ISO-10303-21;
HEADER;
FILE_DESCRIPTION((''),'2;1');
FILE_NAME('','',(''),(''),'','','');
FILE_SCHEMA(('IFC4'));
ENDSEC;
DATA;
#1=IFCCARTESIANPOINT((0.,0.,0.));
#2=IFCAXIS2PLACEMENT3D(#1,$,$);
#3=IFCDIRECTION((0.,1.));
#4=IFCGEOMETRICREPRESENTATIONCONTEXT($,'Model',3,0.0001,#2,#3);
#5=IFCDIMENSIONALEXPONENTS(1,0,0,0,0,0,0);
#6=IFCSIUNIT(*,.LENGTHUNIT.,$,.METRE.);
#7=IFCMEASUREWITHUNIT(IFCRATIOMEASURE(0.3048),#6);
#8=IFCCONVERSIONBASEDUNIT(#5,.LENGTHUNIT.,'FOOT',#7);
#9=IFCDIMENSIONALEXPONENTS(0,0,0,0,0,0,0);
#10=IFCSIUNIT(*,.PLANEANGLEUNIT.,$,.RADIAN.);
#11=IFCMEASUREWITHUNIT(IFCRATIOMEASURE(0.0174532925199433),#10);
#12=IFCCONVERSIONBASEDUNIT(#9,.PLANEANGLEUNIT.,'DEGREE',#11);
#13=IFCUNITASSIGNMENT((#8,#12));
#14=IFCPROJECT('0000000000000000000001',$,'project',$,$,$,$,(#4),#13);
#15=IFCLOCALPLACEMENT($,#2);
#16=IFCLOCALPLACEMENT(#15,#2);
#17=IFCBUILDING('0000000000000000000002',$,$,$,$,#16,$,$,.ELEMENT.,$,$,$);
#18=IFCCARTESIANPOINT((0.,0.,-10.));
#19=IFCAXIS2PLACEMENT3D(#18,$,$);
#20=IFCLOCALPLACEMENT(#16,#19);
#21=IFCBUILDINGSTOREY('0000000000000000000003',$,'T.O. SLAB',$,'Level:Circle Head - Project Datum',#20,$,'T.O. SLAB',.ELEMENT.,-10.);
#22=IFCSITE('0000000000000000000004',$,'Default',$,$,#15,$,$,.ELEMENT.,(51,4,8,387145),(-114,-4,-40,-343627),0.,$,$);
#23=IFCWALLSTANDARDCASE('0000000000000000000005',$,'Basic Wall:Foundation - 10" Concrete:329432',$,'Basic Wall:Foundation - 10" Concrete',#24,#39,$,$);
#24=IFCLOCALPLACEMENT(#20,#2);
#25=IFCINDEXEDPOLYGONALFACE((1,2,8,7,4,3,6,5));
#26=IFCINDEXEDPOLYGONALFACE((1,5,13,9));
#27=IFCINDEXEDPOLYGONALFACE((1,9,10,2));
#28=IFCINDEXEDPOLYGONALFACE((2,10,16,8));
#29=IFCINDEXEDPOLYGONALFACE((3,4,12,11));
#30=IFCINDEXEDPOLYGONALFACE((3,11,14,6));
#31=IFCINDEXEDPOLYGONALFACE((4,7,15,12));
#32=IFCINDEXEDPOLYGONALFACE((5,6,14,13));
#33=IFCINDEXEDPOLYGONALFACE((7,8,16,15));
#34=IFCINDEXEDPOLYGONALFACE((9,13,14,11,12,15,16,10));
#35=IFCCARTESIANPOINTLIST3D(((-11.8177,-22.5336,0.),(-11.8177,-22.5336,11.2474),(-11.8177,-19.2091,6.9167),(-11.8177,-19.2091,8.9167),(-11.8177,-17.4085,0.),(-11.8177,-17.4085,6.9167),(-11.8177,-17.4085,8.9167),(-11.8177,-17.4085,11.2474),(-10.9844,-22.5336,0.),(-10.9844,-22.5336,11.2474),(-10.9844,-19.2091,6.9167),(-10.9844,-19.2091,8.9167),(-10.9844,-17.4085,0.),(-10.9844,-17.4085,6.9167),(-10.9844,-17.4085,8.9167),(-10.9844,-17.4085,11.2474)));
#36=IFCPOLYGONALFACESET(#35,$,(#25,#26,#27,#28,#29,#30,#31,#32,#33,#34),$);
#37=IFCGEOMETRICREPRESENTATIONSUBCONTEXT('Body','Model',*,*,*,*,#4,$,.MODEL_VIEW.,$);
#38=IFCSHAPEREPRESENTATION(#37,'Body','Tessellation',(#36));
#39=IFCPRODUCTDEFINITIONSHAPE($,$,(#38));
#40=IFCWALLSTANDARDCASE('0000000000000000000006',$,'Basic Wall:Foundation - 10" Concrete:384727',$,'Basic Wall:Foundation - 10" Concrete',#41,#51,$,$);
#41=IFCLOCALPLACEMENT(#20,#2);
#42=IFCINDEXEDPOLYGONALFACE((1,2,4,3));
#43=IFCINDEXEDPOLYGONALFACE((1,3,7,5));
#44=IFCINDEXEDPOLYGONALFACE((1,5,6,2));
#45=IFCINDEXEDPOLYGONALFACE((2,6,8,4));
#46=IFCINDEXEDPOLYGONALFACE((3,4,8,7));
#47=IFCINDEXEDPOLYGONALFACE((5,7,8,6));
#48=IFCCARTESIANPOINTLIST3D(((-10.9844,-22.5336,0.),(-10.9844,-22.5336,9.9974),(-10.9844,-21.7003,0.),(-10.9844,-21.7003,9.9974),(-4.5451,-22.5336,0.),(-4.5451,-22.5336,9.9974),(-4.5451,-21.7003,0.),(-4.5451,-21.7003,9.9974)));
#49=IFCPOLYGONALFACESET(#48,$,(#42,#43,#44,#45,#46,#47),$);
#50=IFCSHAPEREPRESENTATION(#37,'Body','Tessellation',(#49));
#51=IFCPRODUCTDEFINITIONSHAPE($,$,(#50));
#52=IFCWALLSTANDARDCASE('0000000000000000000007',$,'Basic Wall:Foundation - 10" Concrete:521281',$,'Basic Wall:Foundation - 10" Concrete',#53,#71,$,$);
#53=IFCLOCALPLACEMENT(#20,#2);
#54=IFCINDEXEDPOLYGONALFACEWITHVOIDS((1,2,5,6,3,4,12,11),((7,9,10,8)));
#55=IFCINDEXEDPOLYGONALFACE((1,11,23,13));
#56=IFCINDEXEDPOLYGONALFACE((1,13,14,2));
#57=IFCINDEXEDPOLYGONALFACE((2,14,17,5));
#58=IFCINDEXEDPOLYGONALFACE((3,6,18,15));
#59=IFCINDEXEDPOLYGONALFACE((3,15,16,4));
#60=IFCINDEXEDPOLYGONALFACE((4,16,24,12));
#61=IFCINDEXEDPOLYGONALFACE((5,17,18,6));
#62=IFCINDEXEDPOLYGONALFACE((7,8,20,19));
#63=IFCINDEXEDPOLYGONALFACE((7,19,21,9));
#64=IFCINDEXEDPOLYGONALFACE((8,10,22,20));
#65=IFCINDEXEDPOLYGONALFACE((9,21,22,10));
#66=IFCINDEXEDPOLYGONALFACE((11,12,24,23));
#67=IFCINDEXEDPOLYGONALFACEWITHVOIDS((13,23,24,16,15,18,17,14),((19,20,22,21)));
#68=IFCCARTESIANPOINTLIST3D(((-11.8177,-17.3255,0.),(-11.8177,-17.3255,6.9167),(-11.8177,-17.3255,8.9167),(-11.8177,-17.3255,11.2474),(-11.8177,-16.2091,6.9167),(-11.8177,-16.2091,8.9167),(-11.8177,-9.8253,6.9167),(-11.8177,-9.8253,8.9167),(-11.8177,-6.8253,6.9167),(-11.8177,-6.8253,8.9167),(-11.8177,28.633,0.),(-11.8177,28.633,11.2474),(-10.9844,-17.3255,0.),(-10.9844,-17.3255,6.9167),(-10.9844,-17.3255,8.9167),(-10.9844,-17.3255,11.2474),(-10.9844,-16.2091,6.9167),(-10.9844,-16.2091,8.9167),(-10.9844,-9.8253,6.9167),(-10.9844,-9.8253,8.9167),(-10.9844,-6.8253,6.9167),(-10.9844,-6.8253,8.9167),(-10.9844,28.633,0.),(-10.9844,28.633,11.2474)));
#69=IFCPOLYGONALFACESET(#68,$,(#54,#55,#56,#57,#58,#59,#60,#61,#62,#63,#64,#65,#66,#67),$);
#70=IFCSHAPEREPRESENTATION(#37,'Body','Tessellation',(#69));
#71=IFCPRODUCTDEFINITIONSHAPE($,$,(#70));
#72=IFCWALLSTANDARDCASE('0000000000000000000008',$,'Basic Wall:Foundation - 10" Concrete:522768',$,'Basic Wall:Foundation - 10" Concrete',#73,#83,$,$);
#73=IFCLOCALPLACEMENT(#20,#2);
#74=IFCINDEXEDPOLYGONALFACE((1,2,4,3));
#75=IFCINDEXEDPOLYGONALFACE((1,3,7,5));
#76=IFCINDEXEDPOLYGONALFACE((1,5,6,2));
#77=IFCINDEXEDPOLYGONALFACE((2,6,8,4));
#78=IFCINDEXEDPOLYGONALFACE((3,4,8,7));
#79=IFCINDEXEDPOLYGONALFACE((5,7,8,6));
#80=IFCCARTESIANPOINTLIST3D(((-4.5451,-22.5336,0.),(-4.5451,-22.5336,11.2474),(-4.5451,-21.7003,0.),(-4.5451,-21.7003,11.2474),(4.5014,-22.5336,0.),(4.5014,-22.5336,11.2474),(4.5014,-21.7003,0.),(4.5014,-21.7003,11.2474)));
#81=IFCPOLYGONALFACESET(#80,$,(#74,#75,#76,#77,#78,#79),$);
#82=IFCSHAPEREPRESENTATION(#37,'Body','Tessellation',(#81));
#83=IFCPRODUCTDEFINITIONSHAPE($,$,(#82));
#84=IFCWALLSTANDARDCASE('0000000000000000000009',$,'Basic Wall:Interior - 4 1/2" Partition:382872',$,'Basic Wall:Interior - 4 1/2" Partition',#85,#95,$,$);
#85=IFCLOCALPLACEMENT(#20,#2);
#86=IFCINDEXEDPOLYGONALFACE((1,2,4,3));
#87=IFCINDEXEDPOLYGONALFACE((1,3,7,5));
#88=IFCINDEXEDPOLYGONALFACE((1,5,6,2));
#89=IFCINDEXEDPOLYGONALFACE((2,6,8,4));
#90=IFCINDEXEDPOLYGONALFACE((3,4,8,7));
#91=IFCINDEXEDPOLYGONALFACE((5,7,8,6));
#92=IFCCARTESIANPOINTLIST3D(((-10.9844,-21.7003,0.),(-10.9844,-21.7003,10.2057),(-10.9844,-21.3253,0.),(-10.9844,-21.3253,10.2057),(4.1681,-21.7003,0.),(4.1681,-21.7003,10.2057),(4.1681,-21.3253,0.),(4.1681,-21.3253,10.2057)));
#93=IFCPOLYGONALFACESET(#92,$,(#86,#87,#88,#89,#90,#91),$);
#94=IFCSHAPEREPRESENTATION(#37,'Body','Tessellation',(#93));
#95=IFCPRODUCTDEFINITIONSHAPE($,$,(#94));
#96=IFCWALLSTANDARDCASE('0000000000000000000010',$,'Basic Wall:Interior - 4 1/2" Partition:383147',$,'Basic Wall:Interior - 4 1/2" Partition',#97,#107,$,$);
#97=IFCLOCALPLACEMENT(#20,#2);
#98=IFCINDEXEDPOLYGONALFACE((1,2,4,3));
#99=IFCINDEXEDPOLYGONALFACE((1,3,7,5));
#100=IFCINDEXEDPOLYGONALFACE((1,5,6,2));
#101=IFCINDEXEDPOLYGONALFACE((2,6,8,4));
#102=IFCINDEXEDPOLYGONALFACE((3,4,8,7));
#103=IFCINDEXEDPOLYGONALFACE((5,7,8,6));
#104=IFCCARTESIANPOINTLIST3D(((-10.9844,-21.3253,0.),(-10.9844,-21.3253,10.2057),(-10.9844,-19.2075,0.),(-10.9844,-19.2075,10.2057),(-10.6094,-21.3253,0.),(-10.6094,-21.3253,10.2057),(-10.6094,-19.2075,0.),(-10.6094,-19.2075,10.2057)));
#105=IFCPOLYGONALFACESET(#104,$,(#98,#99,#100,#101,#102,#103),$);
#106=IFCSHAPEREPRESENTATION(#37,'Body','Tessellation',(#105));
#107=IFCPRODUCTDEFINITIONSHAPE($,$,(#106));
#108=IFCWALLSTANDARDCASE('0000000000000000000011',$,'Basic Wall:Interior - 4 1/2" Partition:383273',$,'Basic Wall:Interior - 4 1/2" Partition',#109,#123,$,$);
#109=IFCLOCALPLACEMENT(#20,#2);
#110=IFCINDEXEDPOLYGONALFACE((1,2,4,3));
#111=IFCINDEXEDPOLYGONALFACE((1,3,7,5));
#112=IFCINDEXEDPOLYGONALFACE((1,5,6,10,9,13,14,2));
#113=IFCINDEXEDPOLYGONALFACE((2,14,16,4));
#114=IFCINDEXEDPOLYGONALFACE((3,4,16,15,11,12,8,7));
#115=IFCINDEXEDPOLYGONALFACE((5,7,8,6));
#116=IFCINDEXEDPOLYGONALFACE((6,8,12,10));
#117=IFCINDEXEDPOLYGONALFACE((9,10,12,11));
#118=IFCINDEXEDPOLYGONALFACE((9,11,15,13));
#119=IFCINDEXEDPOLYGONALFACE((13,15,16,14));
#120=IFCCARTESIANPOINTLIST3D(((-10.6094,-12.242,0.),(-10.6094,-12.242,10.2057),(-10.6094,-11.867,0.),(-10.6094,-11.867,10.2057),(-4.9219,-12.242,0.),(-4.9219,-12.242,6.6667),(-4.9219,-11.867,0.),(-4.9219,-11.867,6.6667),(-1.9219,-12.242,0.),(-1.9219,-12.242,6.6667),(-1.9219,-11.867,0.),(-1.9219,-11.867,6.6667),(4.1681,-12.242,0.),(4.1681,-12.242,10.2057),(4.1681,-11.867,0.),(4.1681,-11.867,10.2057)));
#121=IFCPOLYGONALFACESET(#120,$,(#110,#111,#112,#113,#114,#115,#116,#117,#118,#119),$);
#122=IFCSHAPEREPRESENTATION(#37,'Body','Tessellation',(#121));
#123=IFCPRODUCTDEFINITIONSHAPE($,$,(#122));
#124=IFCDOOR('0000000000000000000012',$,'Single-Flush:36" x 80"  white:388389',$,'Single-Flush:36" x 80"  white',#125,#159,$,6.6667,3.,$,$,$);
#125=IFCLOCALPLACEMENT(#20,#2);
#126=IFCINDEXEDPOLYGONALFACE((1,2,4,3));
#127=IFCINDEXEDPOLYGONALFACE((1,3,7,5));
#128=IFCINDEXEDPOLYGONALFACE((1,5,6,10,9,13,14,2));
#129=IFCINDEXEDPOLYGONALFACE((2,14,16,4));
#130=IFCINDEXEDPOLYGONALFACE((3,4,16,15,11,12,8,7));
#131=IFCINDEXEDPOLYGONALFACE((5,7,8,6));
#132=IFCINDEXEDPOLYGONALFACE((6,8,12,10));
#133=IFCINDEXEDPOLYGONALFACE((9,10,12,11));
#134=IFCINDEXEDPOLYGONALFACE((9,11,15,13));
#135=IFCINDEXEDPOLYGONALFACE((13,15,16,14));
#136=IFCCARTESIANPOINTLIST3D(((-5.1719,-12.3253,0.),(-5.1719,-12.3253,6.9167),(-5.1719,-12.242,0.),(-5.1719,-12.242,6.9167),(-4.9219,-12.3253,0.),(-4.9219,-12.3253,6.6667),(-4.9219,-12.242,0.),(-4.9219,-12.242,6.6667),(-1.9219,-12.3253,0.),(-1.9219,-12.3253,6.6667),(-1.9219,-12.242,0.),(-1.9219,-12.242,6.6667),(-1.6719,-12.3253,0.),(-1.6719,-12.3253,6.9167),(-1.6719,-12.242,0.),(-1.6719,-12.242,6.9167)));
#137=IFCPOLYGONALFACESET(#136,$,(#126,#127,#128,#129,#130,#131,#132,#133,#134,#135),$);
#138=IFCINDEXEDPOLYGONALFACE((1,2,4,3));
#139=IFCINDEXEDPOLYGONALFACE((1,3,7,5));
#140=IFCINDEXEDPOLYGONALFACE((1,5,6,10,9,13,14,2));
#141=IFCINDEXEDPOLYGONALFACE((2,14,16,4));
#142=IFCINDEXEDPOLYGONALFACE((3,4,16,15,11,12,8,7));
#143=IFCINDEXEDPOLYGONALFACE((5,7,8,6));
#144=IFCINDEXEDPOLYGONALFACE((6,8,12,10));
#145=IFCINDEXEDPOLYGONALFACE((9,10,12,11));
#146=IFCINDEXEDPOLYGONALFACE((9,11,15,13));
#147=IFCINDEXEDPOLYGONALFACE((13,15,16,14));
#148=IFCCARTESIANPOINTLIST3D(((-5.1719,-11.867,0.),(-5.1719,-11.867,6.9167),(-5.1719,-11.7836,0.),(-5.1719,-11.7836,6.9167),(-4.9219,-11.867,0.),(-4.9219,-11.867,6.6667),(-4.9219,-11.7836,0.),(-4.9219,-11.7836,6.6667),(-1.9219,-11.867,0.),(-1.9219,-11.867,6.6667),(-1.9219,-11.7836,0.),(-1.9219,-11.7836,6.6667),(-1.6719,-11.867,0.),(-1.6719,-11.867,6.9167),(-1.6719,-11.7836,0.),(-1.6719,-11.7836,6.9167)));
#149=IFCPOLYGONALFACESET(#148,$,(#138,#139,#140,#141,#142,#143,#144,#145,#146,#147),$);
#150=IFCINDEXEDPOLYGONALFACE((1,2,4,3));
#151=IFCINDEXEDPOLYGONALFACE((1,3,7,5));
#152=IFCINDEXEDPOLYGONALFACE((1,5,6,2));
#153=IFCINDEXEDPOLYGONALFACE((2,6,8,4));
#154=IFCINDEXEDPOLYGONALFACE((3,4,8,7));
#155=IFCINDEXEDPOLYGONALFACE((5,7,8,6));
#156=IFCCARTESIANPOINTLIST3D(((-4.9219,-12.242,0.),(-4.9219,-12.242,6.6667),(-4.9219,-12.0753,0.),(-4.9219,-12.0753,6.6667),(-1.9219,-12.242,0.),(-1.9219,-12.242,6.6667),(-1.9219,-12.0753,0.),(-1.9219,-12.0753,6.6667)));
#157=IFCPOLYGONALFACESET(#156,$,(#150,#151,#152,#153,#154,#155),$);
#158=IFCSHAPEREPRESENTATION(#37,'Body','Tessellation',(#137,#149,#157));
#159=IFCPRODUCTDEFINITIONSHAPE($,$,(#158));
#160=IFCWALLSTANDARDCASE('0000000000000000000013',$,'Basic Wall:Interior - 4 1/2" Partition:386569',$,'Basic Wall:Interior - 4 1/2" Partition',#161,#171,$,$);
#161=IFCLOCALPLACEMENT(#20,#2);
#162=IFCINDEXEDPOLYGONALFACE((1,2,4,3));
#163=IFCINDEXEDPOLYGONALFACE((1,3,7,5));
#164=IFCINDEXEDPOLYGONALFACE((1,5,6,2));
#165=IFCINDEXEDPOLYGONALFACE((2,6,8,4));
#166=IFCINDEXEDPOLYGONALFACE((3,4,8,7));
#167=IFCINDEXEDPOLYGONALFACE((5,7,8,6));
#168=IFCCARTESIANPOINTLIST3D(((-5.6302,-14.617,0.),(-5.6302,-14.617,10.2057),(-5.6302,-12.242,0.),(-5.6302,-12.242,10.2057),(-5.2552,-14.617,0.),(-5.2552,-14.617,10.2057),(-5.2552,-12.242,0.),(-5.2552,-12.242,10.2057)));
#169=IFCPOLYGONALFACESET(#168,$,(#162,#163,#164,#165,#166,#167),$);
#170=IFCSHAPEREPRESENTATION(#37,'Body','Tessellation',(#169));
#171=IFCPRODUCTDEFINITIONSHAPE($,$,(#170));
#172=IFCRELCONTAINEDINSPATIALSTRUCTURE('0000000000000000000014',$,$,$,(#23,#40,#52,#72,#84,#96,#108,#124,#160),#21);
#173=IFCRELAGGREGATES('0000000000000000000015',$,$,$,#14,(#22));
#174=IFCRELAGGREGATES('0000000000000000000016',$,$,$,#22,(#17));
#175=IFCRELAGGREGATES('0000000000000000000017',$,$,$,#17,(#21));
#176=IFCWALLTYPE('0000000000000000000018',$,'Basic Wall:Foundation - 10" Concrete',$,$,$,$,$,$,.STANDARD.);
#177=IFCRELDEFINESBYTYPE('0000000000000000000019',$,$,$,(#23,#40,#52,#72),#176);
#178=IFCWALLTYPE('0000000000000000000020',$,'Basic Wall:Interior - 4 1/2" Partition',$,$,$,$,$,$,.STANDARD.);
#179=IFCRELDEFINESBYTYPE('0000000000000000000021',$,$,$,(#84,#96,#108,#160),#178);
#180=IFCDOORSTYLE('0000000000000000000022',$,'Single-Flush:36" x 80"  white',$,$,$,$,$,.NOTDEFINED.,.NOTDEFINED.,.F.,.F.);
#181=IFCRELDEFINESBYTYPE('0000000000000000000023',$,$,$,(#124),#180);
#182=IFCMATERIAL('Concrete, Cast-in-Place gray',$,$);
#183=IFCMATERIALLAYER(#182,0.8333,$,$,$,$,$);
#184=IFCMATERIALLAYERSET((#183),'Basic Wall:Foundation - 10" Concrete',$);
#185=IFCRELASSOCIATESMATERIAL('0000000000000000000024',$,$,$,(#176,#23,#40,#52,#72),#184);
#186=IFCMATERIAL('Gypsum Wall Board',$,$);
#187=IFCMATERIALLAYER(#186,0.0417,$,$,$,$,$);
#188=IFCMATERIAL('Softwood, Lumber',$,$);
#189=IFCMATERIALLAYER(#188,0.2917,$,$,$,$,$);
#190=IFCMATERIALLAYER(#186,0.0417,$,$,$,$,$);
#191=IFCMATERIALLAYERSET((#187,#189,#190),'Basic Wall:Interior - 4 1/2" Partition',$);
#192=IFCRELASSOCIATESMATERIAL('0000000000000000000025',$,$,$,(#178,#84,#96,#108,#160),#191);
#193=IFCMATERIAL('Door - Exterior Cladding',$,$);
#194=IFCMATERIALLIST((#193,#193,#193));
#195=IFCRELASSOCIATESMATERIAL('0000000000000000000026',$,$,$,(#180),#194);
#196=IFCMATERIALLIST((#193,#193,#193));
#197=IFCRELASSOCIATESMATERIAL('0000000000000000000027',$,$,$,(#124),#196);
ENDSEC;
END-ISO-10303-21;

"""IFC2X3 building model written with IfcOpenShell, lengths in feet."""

from ifc_helpers import new_model, entity, si_unit, converted_unit, direction, frame, frame_2d, origin, place, context, subcontext, project, spatial, polyline, rectangle, outline, extrude, source, transform, mapped, material, material_list, layer, layer_set, layer_usage, type_object, type_shapes, element, fill, save


model = new_model("IFC2X3")

# Units and contexts
model_context = context("Model", 3, precision=0.0001, world=origin(), true_north=direction((0.0, 1.0)))
body_context = subcontext(model_context, "Body", "Model", "MODEL_VIEW")
ifc_project = project(units=[converted_unit("LENGTHUNIT", "FOOT", entity("IfcRatioMeasure", 0.3048), si_unit("LENGTHUNIT", "METRE"), dimensions=[1, 0, 0, 0, 0, 0, 0]), converted_unit("PLANEANGLEUNIT", "DEGREE", entity("IfcRatioMeasure", 0.0174532925199433), si_unit("PLANEANGLEUNIT", "RADIAN"), dimensions=[0, 0, 0, 0, 0, 0, 0])], contexts=[model_context])

# Site, building, storey
site_placement = place(None, origin())
site = spatial("IfcSite", under=ifc_project, at=site_placement, Name="Default", CompositionType="ELEMENT", RefLatitude=(51, 4, 8, 387145), RefLongitude=(-114, -4, -40, -343627), RefElevation=0.0)
building_placement = place(site_placement, origin())
building = spatial("IfcBuilding", under=site, at=building_placement, CompositionType="ELEMENT")
storey_placement = place(building_placement, frame((0.0, 0.0, -10.0)))
storey = spatial("IfcBuildingStorey", under=building, at=storey_placement, Name="T.O. SLAB", ObjectType="Level:Circle Head - Project Datum", LongName="T.O. SLAB", CompositionType="ELEMENT", Elevation=-10.0)

# Wall, opening
ifc_material_1 = material(Name="Concrete, Cast-in-Place gray")
ifc_layer_1 = layer(ifc_material_1, 0.8333)
ifc_layer_set_1 = layer_set([ifc_layer_1], Name="Basic Wall:Foundation - 10\" Concrete")
ifc_layer_usage_1 = layer_usage(ifc_layer_set_1, "AXIS2", "NEGATIVE", 0.4167)
wall_type_1 = type_object("IfcWallType", Name="Basic Wall:Foundation - 10\" Concrete", PredefinedType="STANDARD", material=ifc_layer_set_1)
wall_1_placement = place(storey_placement, frame((-11.401, -22.5336, 0.0), z_axis=(0.0, 0.0, 1.0), x_axis=(0.0, 1.0, 0.0)))
wall_1 = element("IfcWallStandardCase", 1, at=wall_1_placement, inside=storey, type_object=wall_type_1, material=ifc_layer_usage_1, Name="Basic Wall:Foundation - 10\" Concrete:329432", ObjectType="Basic Wall:Foundation - 10\" Concrete", context=body_context, shape_type="SweptSolid", body=[
    extrude(rectangle(XDim=5.1252, YDim=0.8333, at=frame_2d((2.5626, 0.0), x_axis=(-1.0, 0.0))), origin(), (0.0, 0.0, 1.0), 11.2474),
])
opening_1_placement = place(wall_1_placement, frame((6.3246, 0.4167, 6.9167)))
element("IfcOpeningElement", 2, at=opening_1_placement, cuts=wall_1, ObjectType="Opening", context=body_context, shape_type="SweptSolid", body=[
    extrude(rectangle(XDim=2.0, YDim=3.0, at=frame_2d((1.0, 1.5), x_axis=(-1.0, 0.0))), frame((0.0, 0.0, 0.0), z_axis=(0.0, -1.0, 0.0), x_axis=(0.0, 0.0, 1.0)), (0.0, 0.0, 1.0), 0.8333),
])

# Wall
ifc_layer_usage_2 = layer_usage(ifc_layer_set_1, "AXIS2", "NEGATIVE", 0.4167)
wall_2_placement = place(storey_placement, frame((-10.9844, -22.117, 0.0)))
element("IfcWallStandardCase", 3, at=wall_2_placement, inside=storey, type_object=wall_type_1, material=ifc_layer_usage_2, Name="Basic Wall:Foundation - 10\" Concrete:384727", ObjectType="Basic Wall:Foundation - 10\" Concrete", context=body_context, shape_type="SweptSolid", body=[
    extrude(rectangle(XDim=6.4392, YDim=0.8333, at=frame_2d((3.2196, 0.0), x_axis=(-1.0, 0.0))), origin(), (0.0, 0.0, 1.0), 9.9974),
])

# Wall, openings
ifc_layer_usage_3 = layer_usage(ifc_layer_set_1, "AXIS2", "NEGATIVE", 0.4167)
wall_3_placement = place(storey_placement, frame((-11.401, -17.3255, 0.0), z_axis=(0.0, 0.0, 1.0), x_axis=(0.0, 1.0, 0.0)))
wall_3 = element("IfcWallStandardCase", 4, at=wall_3_placement, inside=storey, type_object=wall_type_1, material=ifc_layer_usage_3, Name="Basic Wall:Foundation - 10\" Concrete:521281", ObjectType="Basic Wall:Foundation - 10\" Concrete", context=body_context, shape_type="SweptSolid", body=[
    extrude(rectangle(XDim=45.9585, YDim=0.8333, at=frame_2d((22.9792, 0.0), x_axis=(-1.0, 0.0))), origin(), (0.0, 0.0, 1.0), 11.2474),
])
opening_2_placement = place(wall_3_placement, origin())
element("IfcOpeningElement", 5, at=opening_2_placement, cuts=wall_3, ObjectType="Opening", context=body_context, shape_type="SweptSolid", body=[
    extrude(rectangle(XDim=2.0, YDim=3.0, at=frame_2d((0.0, 0.0), x_axis=(0.0, 1.0))), frame((-0.3836, -4.5833, 7.9167), z_axis=(0.0, 1.0, 0.0), x_axis=(1.0, 0.0, 0.0)), (0.0, 0.0, 1.0), 10.0),
])
opening_3_placement = place(wall_3_placement, frame((10.5002, 0.4167, 6.9167)))
element("IfcOpeningElement", 6, at=opening_3_placement, cuts=wall_3, ObjectType="Opening", context=body_context, shape_type="SweptSolid", body=[
    extrude(rectangle(XDim=2.0, YDim=3.0, at=frame_2d((1.0, 1.5), x_axis=(-1.0, 0.0))), frame((0.0, 0.0, 0.0), z_axis=(0.0, -1.0, 0.0), x_axis=(0.0, 0.0, 1.0)), (0.0, 0.0, 1.0), 0.8333),
])

# Walls
ifc_layer_usage_4 = layer_usage(ifc_layer_set_1, "AXIS2", "NEGATIVE", 0.4167)
wall_4_placement = place(storey_placement, frame((-4.5451, -22.117, 0.0)))
element("IfcWallStandardCase", 7, at=wall_4_placement, inside=storey, type_object=wall_type_1, material=ifc_layer_usage_4, Name="Basic Wall:Foundation - 10\" Concrete:522768", ObjectType="Basic Wall:Foundation - 10\" Concrete", context=body_context, shape_type="SweptSolid", body=[
    extrude(rectangle(XDim=9.0466, YDim=0.8333, at=frame_2d((4.5233, 0.0), x_axis=(-1.0, 0.0))), origin(), (0.0, 0.0, 1.0), 11.2474),
])
ifc_material_2 = material(Name="Gypsum Wall Board")
ifc_layer_2 = layer(ifc_material_2, 0.0417)
ifc_material_3 = material(Name="Softwood, Lumber")
ifc_layer_3 = layer(ifc_material_3, 0.2917)
ifc_layer_4 = layer(ifc_material_2, 0.0417)
ifc_layer_set_2 = layer_set([ifc_layer_2, ifc_layer_3, ifc_layer_4], Name="Basic Wall:Interior - 4 1/2\" Partition")
ifc_layer_usage_5 = layer_usage(ifc_layer_set_2, "AXIS2", "NEGATIVE", 0.1875)
wall_type_2 = type_object("IfcWallType", Name="Basic Wall:Interior - 4 1/2\" Partition", PredefinedType="STANDARD", material=ifc_layer_set_2)
wall_5_placement = place(storey_placement, frame((4.1681, -21.5128, 0.0), z_axis=(0.0, 0.0, 1.0), x_axis=(-1.0, 0.0, 0.0)))
element("IfcWallStandardCase", 8, at=wall_5_placement, inside=storey, type_object=wall_type_2, material=ifc_layer_usage_5, Name="Basic Wall:Interior - 4 1/2\" Partition:382872", ObjectType="Basic Wall:Interior - 4 1/2\" Partition", context=body_context, shape_type="SweptSolid", body=[
    extrude(rectangle(XDim=15.1525, YDim=0.375, at=frame_2d((7.5762, 0.0), x_axis=(-1.0, 0.0))), origin(), (0.0, 0.0, 1.0), 10.2057),
])
ifc_layer_usage_6 = layer_usage(ifc_layer_set_2, "AXIS2", "NEGATIVE", 0.1875)
wall_6_placement = place(storey_placement, frame((-10.7969, -21.3253, 0.0), z_axis=(0.0, 0.0, 1.0), x_axis=(0.0, 1.0, 0.0)))
element("IfcWallStandardCase", 9, at=wall_6_placement, inside=storey, type_object=wall_type_2, material=ifc_layer_usage_6, Name="Basic Wall:Interior - 4 1/2\" Partition:383147", ObjectType="Basic Wall:Interior - 4 1/2\" Partition", context=body_context, shape_type="SweptSolid", body=[
    extrude(rectangle(XDim=2.1178, YDim=0.375, at=frame_2d((1.0589, 0.0), x_axis=(-1.0, 0.0))), origin(), (0.0, 0.0, 1.0), 10.2057),
])

# Wall, opening, door
ifc_layer_usage_7 = layer_usage(ifc_layer_set_2, "AXIS2", "NEGATIVE", 0.1875)
wall_7_placement = place(storey_placement, frame((4.1681, -12.0545, 0.0), z_axis=(0.0, 0.0, 1.0), x_axis=(-1.0, 0.0, 0.0)))
wall_7 = element("IfcWallStandardCase", 10, at=wall_7_placement, inside=storey, type_object=wall_type_2, material=ifc_layer_usage_7, Name="Basic Wall:Interior - 4 1/2\" Partition:383273", ObjectType="Basic Wall:Interior - 4 1/2\" Partition", context=body_context, shape_type="SweptSolid", body=[
    extrude(rectangle(XDim=14.7775, YDim=0.375, at=frame_2d((7.3887, 0.0), x_axis=(-1.0, 0.0))), origin(), (0.0, 0.0, 1.0), 10.2057),
])
opening_4_placement = place(wall_7_placement, frame((6.09, -0.1875, 0.0)))
opening_4 = element("IfcOpeningElement", 11, at=opening_4_placement, cuts=wall_7, ObjectType="Opening", context=body_context, shape_type="SweptSolid", body=[
    extrude(rectangle(XDim=3.0, YDim=6.6667, at=frame_2d((3.3333, 1.5), x_axis=(0.0, 1.0))), frame((0.0, 0.0, 0.0), z_axis=(0.0, 1.0, 0.0), x_axis=(0.0, 0.0, 1.0)), (0.0, 0.0, 1.0), 0.375),
])
ifc_material_4 = material(Name="Door - Exterior Cladding")
ifc_material_list_1 = material_list([ifc_material_4, ifc_material_4, ifc_material_4])
ifc_material_list_2 = material_list([ifc_material_4, ifc_material_4, ifc_material_4])
door_style_1 = type_object("IfcDoorStyle", Name="Single-Flush:36\" x 80\"  white", ConstructionType="NOTDEFINED", OperationType="NOTDEFINED", ParameterTakesPrecedence=False, Sizeable=False, material=ifc_material_list_2)
shared_shape_1 = source(origin(), body_context, "Body", "SweptSolid", [
    extrude(outline(polyline([(-1.75, -3.5208), (1.75, -3.5208), (1.75, 3.3958), (1.5, 3.3958), (1.5, -3.2708), (-1.5, -3.2708), (-1.5, 3.3958), (-1.75, 3.3958), (-1.75, -3.5208)])), frame((1.5, 0.375, 3.3958), z_axis=(0.0, 1.0, 0.0), x_axis=(1.0, 0.0, 0.0)), (0.0, 0.0, 1.0), 0.0833),
    extrude(outline(polyline([(-3.5208, -1.75), (3.3958, -1.75), (3.3958, -1.5), (-3.2708, -1.5), (-3.2708, 1.5), (3.3958, 1.5), (3.3958, 1.75), (-3.5208, 1.75), (-3.5208, -1.75)])), frame((1.5, -0.0833, 3.3958), z_axis=(0.0, 1.0, 0.0), x_axis=(0.0, 0.0, -1.0)), (0.0, 0.0, 1.0), 0.0833),
    extrude(rectangle(XDim=0.1667, YDim=3.0, at=frame_2d((0.0, 0.0), x_axis=(1.0, 0.0))), frame((1.5, 0.2917, 0.0), z_axis=(0.0, 0.0, 1.0), x_axis=(0.0, 1.0, 0.0)), (0.0, 0.0, 1.0), 6.6667),
])
type_shapes(door_style_1, [shared_shape_1])
door_1_placement = place(opening_4_placement, origin())
door_1 = element("IfcDoor", 12, at=door_1_placement, inside=storey, type_object=door_style_1, material=ifc_material_list_1, Name="Single-Flush:36\" x 80\"  white:388389", ObjectType="Single-Flush:36\" x 80\"  white", OverallHeight=6.6667, OverallWidth=3.0, context=body_context, shape_type="MappedRepresentation", body=[
    mapped(shared_shape_1, transform((0.0, 0.0, 0.0), scale=1.0)),
])
fill(opening_4, door_1)

# Wall
ifc_layer_usage_8 = layer_usage(ifc_layer_set_2, "AXIS2", "NEGATIVE", 0.1875)
wall_8_placement = place(storey_placement, frame((-5.4427, -12.242, 0.0), z_axis=(0.0, 0.0, 1.0), x_axis=(0.0, -1.0, 0.0)))
element("IfcWallStandardCase", 13, at=wall_8_placement, inside=storey, type_object=wall_type_2, material=ifc_layer_usage_8, Name="Basic Wall:Interior - 4 1/2\" Partition:386569", ObjectType="Basic Wall:Interior - 4 1/2\" Partition", context=body_context, shape_type="SweptSolid", body=[
    extrude(rectangle(XDim=2.375, YDim=0.375, at=frame_2d((1.1875, 0.0), x_axis=(-1.0, 0.0))), origin(), (0.0, 0.0, 1.0), 10.2057),
])

save(model, "model.ifc")
